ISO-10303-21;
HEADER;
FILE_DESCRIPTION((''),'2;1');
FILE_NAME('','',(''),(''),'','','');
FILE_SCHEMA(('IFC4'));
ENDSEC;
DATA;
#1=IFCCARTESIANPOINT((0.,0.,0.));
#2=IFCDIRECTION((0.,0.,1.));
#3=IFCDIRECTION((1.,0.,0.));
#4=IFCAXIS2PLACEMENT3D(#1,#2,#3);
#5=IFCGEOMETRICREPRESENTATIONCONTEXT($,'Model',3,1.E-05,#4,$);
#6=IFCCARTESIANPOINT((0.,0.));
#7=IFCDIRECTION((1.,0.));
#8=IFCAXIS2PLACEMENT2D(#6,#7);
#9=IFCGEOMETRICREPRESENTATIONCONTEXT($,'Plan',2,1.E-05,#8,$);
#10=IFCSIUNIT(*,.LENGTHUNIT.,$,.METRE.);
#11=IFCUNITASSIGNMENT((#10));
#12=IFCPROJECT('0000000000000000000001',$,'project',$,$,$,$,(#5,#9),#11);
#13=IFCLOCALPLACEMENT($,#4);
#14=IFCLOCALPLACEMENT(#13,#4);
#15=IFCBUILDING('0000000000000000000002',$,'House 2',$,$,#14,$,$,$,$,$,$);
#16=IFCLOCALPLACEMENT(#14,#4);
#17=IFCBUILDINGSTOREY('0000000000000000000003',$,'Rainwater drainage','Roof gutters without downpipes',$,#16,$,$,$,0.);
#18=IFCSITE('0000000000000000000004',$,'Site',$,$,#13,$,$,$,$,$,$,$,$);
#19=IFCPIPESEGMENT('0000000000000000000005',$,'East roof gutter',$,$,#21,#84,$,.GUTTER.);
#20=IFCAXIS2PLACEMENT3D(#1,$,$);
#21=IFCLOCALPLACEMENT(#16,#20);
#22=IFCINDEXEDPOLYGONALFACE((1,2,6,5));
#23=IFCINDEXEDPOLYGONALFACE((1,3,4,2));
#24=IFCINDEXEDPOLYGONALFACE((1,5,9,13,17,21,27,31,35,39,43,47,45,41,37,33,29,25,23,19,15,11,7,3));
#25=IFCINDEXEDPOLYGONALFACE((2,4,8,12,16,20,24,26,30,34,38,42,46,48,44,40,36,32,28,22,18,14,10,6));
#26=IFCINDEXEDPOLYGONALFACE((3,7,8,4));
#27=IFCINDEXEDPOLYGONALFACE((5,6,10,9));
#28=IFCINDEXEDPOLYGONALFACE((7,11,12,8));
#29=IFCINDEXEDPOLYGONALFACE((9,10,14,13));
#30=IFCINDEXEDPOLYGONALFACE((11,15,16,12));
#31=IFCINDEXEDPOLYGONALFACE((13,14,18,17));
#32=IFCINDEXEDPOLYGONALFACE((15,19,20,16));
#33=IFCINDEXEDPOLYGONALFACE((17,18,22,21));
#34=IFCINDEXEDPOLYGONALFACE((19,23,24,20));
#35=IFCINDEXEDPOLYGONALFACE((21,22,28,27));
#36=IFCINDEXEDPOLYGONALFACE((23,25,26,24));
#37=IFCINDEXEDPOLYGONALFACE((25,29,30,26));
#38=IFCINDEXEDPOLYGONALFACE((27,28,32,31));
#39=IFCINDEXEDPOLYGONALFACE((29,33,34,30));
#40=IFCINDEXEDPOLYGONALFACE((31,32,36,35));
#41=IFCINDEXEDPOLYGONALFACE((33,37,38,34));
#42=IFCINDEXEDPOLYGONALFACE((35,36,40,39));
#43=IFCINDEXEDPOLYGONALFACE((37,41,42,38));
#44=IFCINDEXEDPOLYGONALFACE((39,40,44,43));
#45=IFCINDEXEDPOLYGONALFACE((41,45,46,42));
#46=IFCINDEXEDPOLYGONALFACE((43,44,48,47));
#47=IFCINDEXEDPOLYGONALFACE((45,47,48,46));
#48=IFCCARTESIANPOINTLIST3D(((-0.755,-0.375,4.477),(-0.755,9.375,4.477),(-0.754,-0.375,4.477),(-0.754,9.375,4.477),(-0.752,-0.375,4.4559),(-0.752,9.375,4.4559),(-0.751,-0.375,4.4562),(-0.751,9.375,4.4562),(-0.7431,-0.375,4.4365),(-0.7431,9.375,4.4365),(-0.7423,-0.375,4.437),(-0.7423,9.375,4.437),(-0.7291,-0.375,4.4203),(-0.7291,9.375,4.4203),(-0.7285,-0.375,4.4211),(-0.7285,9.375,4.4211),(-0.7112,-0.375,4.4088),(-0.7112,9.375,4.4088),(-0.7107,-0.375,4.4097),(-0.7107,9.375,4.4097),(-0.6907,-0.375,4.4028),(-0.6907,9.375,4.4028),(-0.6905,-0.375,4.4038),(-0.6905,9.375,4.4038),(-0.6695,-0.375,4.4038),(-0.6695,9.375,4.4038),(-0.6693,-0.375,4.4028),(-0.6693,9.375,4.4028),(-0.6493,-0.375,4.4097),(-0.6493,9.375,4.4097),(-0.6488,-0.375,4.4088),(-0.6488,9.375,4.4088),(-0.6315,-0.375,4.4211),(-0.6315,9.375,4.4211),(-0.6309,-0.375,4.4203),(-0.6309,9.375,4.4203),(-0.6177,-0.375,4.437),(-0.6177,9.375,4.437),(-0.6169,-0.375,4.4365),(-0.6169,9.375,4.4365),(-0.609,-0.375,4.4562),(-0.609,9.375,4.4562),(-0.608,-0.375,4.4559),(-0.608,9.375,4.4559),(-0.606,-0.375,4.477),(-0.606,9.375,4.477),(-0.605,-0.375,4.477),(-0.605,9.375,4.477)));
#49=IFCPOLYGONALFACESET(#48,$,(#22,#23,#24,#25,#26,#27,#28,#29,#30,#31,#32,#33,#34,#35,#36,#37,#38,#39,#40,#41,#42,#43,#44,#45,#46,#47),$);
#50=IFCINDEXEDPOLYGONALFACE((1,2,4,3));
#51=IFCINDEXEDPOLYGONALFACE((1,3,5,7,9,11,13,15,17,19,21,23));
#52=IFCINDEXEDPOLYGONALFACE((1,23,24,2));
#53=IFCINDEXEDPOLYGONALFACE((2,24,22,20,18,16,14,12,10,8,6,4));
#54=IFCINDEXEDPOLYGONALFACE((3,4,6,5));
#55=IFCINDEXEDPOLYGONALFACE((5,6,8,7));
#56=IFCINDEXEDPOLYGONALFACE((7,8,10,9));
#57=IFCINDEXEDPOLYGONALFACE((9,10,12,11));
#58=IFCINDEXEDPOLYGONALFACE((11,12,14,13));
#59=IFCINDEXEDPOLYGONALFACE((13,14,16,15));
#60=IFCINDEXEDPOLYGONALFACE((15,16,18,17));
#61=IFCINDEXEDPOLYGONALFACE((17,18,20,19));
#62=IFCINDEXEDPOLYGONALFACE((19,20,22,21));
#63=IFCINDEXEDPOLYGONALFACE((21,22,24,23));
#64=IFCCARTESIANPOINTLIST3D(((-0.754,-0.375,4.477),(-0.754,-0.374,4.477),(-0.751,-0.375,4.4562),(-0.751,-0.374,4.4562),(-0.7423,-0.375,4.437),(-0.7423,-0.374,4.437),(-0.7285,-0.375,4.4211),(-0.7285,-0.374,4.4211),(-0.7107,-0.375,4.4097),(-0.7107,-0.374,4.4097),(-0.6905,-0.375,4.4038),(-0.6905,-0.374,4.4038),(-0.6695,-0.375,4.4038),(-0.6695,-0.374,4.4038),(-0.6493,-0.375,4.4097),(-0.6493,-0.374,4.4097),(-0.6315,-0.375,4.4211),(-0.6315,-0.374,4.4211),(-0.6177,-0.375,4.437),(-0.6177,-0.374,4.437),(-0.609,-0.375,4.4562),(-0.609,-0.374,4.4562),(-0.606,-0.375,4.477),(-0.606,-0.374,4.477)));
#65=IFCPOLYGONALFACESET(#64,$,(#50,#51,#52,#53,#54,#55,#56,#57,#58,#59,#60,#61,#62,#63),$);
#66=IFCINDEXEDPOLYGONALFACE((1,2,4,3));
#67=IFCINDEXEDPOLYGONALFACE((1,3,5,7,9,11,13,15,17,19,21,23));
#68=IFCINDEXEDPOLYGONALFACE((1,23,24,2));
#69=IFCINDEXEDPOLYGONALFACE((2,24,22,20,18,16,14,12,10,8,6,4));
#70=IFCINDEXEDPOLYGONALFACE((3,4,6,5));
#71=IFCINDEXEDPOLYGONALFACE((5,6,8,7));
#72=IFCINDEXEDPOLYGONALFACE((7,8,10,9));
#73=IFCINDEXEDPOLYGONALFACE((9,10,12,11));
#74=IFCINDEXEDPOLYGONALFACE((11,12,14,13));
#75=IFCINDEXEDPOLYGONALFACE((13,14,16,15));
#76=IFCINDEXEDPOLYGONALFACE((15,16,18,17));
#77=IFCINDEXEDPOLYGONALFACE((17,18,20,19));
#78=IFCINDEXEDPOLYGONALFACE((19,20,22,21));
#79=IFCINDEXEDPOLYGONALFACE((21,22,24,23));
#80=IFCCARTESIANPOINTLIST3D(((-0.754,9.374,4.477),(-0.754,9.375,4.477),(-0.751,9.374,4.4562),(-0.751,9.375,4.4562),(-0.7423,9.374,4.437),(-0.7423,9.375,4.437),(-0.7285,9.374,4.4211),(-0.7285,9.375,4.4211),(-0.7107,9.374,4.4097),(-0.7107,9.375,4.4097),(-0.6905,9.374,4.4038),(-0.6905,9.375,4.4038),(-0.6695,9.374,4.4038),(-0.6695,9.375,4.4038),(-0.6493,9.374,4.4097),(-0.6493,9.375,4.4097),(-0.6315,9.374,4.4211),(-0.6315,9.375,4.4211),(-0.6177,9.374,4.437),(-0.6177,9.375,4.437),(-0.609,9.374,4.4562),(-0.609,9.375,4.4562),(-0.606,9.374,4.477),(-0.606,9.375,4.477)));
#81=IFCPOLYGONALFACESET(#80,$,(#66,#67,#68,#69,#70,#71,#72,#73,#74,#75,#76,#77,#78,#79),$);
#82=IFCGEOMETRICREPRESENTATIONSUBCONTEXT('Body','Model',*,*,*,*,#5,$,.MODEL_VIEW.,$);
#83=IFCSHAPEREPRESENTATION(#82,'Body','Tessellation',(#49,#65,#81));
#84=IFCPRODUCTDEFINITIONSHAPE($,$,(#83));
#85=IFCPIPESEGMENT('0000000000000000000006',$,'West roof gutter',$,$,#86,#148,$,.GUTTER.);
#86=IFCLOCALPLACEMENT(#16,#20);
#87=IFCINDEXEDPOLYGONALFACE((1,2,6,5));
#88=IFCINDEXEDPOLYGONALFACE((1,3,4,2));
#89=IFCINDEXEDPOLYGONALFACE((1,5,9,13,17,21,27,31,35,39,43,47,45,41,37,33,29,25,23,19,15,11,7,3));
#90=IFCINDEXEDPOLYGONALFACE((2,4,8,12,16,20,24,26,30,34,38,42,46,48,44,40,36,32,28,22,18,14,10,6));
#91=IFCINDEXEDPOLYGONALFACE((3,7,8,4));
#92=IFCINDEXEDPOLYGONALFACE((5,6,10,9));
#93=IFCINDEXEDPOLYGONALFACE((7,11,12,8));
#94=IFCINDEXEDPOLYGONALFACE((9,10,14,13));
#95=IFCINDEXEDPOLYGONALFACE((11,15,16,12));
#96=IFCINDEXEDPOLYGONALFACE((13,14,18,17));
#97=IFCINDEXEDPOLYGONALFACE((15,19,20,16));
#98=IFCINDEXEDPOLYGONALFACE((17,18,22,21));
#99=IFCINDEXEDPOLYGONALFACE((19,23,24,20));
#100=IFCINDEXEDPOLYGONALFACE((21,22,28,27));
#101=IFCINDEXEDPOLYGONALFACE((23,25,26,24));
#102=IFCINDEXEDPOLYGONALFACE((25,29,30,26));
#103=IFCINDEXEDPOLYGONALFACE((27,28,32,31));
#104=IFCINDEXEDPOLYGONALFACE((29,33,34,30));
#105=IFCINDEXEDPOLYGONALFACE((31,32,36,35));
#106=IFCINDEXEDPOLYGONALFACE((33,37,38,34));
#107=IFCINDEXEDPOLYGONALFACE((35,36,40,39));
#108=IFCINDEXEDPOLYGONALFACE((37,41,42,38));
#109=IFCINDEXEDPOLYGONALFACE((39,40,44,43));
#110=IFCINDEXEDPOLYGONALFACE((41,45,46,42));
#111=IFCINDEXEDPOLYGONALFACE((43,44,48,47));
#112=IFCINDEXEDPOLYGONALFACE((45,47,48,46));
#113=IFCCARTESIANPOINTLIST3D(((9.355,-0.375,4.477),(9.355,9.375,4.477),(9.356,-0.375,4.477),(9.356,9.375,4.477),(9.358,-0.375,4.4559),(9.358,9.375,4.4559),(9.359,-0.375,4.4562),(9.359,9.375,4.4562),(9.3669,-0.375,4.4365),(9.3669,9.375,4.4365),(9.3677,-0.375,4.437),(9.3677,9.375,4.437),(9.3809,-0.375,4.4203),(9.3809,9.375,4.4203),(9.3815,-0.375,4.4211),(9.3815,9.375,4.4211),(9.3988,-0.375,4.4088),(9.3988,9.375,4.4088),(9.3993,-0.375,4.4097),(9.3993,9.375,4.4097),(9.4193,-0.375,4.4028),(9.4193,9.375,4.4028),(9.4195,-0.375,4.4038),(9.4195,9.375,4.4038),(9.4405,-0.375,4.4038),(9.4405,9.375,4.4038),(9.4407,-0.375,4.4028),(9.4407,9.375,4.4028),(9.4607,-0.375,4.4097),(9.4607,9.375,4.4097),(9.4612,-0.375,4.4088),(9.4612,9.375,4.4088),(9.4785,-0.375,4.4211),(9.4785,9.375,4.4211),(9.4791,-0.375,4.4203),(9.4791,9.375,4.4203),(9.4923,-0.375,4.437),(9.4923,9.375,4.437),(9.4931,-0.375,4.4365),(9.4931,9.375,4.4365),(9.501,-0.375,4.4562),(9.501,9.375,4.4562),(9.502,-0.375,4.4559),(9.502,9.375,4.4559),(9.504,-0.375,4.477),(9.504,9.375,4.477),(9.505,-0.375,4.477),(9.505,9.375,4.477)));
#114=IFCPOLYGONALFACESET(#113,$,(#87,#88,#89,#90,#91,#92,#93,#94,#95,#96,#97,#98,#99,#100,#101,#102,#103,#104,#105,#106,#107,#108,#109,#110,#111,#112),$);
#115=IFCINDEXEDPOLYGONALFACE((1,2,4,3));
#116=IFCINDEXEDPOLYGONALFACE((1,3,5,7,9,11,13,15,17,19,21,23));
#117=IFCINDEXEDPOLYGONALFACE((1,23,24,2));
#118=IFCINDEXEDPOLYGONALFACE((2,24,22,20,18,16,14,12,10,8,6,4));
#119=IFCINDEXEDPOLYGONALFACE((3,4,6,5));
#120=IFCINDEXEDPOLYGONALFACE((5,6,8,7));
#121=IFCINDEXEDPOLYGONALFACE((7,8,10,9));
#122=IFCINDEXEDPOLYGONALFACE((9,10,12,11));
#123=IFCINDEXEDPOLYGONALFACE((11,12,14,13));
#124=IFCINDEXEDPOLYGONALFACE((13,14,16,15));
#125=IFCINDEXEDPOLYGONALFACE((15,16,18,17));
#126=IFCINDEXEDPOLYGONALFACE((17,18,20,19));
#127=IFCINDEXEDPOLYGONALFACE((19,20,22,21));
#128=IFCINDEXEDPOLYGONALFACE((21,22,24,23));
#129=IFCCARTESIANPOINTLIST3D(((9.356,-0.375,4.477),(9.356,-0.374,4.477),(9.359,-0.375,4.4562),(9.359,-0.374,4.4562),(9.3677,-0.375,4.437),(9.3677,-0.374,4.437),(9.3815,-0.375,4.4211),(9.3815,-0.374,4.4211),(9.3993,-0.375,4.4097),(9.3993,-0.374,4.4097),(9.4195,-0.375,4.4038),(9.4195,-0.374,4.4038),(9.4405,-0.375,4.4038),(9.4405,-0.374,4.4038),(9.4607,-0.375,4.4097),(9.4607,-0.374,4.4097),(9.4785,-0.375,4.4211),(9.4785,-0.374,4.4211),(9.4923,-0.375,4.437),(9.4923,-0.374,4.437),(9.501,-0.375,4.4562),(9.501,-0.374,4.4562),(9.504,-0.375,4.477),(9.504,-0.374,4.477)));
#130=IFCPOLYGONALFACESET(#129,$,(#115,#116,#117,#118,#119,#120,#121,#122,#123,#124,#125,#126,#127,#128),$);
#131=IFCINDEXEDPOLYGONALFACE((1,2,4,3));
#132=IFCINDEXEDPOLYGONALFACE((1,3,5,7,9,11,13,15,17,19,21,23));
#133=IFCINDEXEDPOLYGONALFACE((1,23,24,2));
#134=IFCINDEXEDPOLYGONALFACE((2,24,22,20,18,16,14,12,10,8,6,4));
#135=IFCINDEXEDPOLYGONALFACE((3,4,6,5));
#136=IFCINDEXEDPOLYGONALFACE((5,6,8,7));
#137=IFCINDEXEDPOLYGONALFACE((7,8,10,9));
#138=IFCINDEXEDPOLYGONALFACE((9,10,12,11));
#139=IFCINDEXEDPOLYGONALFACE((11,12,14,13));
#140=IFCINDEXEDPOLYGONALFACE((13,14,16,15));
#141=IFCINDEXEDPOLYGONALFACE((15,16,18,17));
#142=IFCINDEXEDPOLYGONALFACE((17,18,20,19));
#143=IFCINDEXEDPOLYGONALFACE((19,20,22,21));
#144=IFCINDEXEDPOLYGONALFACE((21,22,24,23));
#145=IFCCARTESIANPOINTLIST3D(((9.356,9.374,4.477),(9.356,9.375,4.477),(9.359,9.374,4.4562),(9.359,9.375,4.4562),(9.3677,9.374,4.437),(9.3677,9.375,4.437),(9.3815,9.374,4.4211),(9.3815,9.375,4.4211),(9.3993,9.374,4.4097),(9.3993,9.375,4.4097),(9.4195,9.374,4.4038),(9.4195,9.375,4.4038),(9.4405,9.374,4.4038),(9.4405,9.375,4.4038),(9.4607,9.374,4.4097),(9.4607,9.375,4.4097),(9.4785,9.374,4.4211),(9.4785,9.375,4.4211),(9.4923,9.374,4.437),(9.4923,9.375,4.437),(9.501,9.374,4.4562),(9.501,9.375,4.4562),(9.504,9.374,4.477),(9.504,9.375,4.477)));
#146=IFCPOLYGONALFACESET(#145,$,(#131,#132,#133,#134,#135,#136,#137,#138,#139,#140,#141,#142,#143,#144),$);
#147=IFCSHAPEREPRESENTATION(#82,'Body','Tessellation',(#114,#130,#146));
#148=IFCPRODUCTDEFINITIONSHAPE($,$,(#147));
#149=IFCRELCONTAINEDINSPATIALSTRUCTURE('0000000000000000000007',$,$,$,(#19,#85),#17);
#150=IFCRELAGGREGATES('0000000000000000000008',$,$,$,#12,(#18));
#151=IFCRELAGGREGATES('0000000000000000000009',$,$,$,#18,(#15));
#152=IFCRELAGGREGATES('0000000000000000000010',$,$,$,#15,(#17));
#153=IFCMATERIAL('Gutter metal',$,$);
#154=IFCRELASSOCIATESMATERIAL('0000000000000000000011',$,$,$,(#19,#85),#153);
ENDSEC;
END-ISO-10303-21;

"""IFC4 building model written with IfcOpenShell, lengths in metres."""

from ifc_helpers import new_model, si_unit, frame, origin_with_axes, origin_2d_with_axis, place, context, subcontext, project, spatial, line, arc, indexed_curve, outline, extrude, material, element, save


model = new_model("IFC4")

# Units and contexts
model_context = context("Model", 3, precision=1e-05, world=origin_with_axes())
plan_context = context("Plan", 2, precision=1e-05, world=origin_2d_with_axis())
body_context = subcontext(model_context, "Body", "Model", "MODEL_VIEW")
ifc_project = project(units=[si_unit("LENGTHUNIT", "METRE")], contexts=[model_context, plan_context])

# Site, building, storey
site_placement = place(None, origin_with_axes())
site = spatial("IfcSite", under=ifc_project, at=site_placement, Name="Site")
building_placement = place(site_placement, origin_with_axes())
building = spatial("IfcBuilding", under=site, at=building_placement, Name="House 2")
storey_placement = place(building_placement, origin_with_axes())
storey = spatial("IfcBuildingStorey", under=building, at=storey_placement, Name="Rainwater drainage", Description="Roof gutters without downpipes", Elevation=0.0)

# Pipe segments
ifc_material = material(Name="Gutter metal")
pipe_segment_1_placement = place(storey_placement, frame((-0.68, -0.375, 4.477), z_axis=(0.0, 1.0, 0.0), x_axis=(-1.0, 0.0, 0.0)))
element("IfcPipeSegment", 1, at=pipe_segment_1_placement, inside=storey, material=ifc_material, Name="East roof gutter", PredefinedType="GUTTER", context=body_context, shape_type="SweptSolid", body=[
    extrude(outline(indexed_curve([(-0.075, 0.0), (0.0, -0.075), (0.075, 0.0), (0.074, 0.0), (0.0, -0.074), (-0.074, 0.0)], segments=[arc(1, 2, 3), line(3, 4), arc(4, 5, 6), line(6, 1)])), origin_with_axes(), (0.0, 0.0, 1.0), 9.75),
    extrude(outline(indexed_curve([(-0.074, 0.0), (0.0, -0.074), (0.074, 0.0)], segments=[arc(1, 2, 3), line(3, 1)])), origin_with_axes(), (0.0, 0.0, 1.0), 0.001),
    extrude(outline(indexed_curve([(-0.074, 0.0), (0.0, -0.074), (0.074, 0.0)], segments=[arc(1, 2, 3), line(3, 1)])), frame((0.0, 0.0, 9.749), z_axis=(0.0, 0.0, 1.0), x_axis=(1.0, 0.0, 0.0)), (0.0, 0.0, 1.0), 0.001),
])
pipe_segment_2_placement = place(storey_placement, frame((9.43, -0.375, 4.477), z_axis=(0.0, 1.0, 0.0), x_axis=(-1.0, 0.0, 0.0)))
element("IfcPipeSegment", 2, at=pipe_segment_2_placement, inside=storey, material=ifc_material, Name="West roof gutter", PredefinedType="GUTTER", context=body_context, shape_type="SweptSolid", body=[
    extrude(outline(indexed_curve([(-0.075, 0.0), (0.0, -0.075), (0.075, 0.0), (0.074, 0.0), (0.0, -0.074), (-0.074, 0.0)], segments=[arc(1, 2, 3), line(3, 4), arc(4, 5, 6), line(6, 1)])), origin_with_axes(), (0.0, 0.0, 1.0), 9.75),
    extrude(outline(indexed_curve([(-0.074, 0.0), (0.0, -0.074), (0.074, 0.0)], segments=[arc(1, 2, 3), line(3, 1)])), origin_with_axes(), (0.0, 0.0, 1.0), 0.001),
    extrude(outline(indexed_curve([(-0.074, 0.0), (0.0, -0.074), (0.074, 0.0)], segments=[arc(1, 2, 3), line(3, 1)])), frame((0.0, 0.0, 9.749), z_axis=(0.0, 0.0, 1.0), x_axis=(1.0, 0.0, 0.0)), (0.0, 0.0, 1.0), 0.001),
])

save(model, "model.ifc")
